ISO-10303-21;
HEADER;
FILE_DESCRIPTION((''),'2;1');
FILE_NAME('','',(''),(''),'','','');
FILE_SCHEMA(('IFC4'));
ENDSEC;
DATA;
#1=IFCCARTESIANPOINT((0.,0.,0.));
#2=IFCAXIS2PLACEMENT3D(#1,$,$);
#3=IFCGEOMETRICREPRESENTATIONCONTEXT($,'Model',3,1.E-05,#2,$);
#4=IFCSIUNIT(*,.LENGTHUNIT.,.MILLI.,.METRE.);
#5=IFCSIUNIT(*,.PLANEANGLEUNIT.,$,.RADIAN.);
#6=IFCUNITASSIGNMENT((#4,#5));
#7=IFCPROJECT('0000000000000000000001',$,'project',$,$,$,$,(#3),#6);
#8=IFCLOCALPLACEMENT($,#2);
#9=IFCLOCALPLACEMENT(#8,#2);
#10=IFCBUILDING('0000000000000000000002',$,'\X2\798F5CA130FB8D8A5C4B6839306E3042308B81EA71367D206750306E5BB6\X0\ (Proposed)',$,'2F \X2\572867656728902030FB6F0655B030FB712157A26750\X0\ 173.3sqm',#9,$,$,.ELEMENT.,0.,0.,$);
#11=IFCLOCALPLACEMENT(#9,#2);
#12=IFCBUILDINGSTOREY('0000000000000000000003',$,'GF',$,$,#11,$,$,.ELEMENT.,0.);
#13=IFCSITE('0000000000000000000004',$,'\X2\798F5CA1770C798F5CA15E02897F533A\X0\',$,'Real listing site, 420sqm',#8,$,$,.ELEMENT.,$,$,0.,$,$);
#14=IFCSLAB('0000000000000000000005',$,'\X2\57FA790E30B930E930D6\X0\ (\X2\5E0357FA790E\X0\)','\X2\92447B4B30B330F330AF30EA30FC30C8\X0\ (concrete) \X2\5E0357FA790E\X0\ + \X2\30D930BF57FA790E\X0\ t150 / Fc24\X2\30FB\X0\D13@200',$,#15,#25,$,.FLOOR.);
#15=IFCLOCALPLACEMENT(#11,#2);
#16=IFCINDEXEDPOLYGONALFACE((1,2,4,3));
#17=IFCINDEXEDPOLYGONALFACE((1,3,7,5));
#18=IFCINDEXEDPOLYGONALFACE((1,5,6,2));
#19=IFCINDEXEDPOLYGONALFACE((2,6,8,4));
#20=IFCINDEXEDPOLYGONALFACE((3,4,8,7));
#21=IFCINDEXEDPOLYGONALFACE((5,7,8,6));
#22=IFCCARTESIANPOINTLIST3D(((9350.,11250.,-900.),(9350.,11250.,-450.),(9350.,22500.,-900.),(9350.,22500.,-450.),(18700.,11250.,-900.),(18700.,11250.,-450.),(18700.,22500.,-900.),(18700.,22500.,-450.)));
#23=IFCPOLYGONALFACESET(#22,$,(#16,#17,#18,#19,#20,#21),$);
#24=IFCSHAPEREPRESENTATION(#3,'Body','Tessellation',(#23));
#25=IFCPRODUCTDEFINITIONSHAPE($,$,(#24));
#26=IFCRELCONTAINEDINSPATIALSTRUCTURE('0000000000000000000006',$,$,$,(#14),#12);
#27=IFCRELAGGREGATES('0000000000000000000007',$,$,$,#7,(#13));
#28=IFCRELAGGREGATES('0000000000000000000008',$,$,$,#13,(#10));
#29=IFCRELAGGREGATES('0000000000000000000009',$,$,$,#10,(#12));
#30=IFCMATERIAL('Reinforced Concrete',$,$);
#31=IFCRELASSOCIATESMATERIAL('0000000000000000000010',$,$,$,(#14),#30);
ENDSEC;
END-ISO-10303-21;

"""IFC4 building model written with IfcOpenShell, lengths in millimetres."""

from ifc_helpers import new_model, si_unit, frame, frame_2d, origin, place, context, project, spatial, rectangle, extrude, material, element, save


model = new_model("IFC4")

# Units and contexts
model_context = context("Model", 3, precision=1e-05, world=origin())
ifc_project = project(units=[si_unit("LENGTHUNIT", "METRE", prefix="MILLI"), si_unit("PLANEANGLEUNIT", "RADIAN")], contexts=[model_context])

# Site, building, storey
site_placement = place(None, origin())
site = spatial("IfcSite", under=ifc_project, at=site_placement, Name="福岡県福岡市西区", ObjectType="Real listing site, 420sqm", CompositionType="ELEMENT", RefElevation=0.0)
building_placement = place(site_placement, origin())
building = spatial("IfcBuilding", under=site, at=building_placement, Name="福岡・越屋根のある自然素材の家 (Proposed)", ObjectType="2F 在来木造・漆喰・無垢材 173.3sqm", CompositionType="ELEMENT", ElevationOfRefHeight=0.0, ElevationOfTerrain=0.0)
storey_placement = place(building_placement, origin())
storey = spatial("IfcBuildingStorey", under=building, at=storey_placement, Name="GF", CompositionType="ELEMENT", Elevation=0.0)

# Slab
ifc_material_1 = material(Name="Reinforced Concrete")
slab_1_placement = place(storey_placement, frame((4675.0, 5625.0, -450.0)))
element("IfcSlab", 1, at=slab_1_placement, inside=storey, material=ifc_material_1, Name="基礎スラブ (布基礎)", Description="鉄筋コンクリート (concrete) 布基礎 + ベタ基礎 t150 / Fc24・D13@200", PredefinedType="FLOOR", context=model_context, shape_type="SweptSolid", body=[
    extrude(rectangle(XDim=9350.0, YDim=11250.0, at=frame_2d((4675.0, 5625.0))), frame((4675.0, 5625.0, -450.0)), (0.0, 0.0, 1.0), 450.0),
])

save(model, "model.ifc")
